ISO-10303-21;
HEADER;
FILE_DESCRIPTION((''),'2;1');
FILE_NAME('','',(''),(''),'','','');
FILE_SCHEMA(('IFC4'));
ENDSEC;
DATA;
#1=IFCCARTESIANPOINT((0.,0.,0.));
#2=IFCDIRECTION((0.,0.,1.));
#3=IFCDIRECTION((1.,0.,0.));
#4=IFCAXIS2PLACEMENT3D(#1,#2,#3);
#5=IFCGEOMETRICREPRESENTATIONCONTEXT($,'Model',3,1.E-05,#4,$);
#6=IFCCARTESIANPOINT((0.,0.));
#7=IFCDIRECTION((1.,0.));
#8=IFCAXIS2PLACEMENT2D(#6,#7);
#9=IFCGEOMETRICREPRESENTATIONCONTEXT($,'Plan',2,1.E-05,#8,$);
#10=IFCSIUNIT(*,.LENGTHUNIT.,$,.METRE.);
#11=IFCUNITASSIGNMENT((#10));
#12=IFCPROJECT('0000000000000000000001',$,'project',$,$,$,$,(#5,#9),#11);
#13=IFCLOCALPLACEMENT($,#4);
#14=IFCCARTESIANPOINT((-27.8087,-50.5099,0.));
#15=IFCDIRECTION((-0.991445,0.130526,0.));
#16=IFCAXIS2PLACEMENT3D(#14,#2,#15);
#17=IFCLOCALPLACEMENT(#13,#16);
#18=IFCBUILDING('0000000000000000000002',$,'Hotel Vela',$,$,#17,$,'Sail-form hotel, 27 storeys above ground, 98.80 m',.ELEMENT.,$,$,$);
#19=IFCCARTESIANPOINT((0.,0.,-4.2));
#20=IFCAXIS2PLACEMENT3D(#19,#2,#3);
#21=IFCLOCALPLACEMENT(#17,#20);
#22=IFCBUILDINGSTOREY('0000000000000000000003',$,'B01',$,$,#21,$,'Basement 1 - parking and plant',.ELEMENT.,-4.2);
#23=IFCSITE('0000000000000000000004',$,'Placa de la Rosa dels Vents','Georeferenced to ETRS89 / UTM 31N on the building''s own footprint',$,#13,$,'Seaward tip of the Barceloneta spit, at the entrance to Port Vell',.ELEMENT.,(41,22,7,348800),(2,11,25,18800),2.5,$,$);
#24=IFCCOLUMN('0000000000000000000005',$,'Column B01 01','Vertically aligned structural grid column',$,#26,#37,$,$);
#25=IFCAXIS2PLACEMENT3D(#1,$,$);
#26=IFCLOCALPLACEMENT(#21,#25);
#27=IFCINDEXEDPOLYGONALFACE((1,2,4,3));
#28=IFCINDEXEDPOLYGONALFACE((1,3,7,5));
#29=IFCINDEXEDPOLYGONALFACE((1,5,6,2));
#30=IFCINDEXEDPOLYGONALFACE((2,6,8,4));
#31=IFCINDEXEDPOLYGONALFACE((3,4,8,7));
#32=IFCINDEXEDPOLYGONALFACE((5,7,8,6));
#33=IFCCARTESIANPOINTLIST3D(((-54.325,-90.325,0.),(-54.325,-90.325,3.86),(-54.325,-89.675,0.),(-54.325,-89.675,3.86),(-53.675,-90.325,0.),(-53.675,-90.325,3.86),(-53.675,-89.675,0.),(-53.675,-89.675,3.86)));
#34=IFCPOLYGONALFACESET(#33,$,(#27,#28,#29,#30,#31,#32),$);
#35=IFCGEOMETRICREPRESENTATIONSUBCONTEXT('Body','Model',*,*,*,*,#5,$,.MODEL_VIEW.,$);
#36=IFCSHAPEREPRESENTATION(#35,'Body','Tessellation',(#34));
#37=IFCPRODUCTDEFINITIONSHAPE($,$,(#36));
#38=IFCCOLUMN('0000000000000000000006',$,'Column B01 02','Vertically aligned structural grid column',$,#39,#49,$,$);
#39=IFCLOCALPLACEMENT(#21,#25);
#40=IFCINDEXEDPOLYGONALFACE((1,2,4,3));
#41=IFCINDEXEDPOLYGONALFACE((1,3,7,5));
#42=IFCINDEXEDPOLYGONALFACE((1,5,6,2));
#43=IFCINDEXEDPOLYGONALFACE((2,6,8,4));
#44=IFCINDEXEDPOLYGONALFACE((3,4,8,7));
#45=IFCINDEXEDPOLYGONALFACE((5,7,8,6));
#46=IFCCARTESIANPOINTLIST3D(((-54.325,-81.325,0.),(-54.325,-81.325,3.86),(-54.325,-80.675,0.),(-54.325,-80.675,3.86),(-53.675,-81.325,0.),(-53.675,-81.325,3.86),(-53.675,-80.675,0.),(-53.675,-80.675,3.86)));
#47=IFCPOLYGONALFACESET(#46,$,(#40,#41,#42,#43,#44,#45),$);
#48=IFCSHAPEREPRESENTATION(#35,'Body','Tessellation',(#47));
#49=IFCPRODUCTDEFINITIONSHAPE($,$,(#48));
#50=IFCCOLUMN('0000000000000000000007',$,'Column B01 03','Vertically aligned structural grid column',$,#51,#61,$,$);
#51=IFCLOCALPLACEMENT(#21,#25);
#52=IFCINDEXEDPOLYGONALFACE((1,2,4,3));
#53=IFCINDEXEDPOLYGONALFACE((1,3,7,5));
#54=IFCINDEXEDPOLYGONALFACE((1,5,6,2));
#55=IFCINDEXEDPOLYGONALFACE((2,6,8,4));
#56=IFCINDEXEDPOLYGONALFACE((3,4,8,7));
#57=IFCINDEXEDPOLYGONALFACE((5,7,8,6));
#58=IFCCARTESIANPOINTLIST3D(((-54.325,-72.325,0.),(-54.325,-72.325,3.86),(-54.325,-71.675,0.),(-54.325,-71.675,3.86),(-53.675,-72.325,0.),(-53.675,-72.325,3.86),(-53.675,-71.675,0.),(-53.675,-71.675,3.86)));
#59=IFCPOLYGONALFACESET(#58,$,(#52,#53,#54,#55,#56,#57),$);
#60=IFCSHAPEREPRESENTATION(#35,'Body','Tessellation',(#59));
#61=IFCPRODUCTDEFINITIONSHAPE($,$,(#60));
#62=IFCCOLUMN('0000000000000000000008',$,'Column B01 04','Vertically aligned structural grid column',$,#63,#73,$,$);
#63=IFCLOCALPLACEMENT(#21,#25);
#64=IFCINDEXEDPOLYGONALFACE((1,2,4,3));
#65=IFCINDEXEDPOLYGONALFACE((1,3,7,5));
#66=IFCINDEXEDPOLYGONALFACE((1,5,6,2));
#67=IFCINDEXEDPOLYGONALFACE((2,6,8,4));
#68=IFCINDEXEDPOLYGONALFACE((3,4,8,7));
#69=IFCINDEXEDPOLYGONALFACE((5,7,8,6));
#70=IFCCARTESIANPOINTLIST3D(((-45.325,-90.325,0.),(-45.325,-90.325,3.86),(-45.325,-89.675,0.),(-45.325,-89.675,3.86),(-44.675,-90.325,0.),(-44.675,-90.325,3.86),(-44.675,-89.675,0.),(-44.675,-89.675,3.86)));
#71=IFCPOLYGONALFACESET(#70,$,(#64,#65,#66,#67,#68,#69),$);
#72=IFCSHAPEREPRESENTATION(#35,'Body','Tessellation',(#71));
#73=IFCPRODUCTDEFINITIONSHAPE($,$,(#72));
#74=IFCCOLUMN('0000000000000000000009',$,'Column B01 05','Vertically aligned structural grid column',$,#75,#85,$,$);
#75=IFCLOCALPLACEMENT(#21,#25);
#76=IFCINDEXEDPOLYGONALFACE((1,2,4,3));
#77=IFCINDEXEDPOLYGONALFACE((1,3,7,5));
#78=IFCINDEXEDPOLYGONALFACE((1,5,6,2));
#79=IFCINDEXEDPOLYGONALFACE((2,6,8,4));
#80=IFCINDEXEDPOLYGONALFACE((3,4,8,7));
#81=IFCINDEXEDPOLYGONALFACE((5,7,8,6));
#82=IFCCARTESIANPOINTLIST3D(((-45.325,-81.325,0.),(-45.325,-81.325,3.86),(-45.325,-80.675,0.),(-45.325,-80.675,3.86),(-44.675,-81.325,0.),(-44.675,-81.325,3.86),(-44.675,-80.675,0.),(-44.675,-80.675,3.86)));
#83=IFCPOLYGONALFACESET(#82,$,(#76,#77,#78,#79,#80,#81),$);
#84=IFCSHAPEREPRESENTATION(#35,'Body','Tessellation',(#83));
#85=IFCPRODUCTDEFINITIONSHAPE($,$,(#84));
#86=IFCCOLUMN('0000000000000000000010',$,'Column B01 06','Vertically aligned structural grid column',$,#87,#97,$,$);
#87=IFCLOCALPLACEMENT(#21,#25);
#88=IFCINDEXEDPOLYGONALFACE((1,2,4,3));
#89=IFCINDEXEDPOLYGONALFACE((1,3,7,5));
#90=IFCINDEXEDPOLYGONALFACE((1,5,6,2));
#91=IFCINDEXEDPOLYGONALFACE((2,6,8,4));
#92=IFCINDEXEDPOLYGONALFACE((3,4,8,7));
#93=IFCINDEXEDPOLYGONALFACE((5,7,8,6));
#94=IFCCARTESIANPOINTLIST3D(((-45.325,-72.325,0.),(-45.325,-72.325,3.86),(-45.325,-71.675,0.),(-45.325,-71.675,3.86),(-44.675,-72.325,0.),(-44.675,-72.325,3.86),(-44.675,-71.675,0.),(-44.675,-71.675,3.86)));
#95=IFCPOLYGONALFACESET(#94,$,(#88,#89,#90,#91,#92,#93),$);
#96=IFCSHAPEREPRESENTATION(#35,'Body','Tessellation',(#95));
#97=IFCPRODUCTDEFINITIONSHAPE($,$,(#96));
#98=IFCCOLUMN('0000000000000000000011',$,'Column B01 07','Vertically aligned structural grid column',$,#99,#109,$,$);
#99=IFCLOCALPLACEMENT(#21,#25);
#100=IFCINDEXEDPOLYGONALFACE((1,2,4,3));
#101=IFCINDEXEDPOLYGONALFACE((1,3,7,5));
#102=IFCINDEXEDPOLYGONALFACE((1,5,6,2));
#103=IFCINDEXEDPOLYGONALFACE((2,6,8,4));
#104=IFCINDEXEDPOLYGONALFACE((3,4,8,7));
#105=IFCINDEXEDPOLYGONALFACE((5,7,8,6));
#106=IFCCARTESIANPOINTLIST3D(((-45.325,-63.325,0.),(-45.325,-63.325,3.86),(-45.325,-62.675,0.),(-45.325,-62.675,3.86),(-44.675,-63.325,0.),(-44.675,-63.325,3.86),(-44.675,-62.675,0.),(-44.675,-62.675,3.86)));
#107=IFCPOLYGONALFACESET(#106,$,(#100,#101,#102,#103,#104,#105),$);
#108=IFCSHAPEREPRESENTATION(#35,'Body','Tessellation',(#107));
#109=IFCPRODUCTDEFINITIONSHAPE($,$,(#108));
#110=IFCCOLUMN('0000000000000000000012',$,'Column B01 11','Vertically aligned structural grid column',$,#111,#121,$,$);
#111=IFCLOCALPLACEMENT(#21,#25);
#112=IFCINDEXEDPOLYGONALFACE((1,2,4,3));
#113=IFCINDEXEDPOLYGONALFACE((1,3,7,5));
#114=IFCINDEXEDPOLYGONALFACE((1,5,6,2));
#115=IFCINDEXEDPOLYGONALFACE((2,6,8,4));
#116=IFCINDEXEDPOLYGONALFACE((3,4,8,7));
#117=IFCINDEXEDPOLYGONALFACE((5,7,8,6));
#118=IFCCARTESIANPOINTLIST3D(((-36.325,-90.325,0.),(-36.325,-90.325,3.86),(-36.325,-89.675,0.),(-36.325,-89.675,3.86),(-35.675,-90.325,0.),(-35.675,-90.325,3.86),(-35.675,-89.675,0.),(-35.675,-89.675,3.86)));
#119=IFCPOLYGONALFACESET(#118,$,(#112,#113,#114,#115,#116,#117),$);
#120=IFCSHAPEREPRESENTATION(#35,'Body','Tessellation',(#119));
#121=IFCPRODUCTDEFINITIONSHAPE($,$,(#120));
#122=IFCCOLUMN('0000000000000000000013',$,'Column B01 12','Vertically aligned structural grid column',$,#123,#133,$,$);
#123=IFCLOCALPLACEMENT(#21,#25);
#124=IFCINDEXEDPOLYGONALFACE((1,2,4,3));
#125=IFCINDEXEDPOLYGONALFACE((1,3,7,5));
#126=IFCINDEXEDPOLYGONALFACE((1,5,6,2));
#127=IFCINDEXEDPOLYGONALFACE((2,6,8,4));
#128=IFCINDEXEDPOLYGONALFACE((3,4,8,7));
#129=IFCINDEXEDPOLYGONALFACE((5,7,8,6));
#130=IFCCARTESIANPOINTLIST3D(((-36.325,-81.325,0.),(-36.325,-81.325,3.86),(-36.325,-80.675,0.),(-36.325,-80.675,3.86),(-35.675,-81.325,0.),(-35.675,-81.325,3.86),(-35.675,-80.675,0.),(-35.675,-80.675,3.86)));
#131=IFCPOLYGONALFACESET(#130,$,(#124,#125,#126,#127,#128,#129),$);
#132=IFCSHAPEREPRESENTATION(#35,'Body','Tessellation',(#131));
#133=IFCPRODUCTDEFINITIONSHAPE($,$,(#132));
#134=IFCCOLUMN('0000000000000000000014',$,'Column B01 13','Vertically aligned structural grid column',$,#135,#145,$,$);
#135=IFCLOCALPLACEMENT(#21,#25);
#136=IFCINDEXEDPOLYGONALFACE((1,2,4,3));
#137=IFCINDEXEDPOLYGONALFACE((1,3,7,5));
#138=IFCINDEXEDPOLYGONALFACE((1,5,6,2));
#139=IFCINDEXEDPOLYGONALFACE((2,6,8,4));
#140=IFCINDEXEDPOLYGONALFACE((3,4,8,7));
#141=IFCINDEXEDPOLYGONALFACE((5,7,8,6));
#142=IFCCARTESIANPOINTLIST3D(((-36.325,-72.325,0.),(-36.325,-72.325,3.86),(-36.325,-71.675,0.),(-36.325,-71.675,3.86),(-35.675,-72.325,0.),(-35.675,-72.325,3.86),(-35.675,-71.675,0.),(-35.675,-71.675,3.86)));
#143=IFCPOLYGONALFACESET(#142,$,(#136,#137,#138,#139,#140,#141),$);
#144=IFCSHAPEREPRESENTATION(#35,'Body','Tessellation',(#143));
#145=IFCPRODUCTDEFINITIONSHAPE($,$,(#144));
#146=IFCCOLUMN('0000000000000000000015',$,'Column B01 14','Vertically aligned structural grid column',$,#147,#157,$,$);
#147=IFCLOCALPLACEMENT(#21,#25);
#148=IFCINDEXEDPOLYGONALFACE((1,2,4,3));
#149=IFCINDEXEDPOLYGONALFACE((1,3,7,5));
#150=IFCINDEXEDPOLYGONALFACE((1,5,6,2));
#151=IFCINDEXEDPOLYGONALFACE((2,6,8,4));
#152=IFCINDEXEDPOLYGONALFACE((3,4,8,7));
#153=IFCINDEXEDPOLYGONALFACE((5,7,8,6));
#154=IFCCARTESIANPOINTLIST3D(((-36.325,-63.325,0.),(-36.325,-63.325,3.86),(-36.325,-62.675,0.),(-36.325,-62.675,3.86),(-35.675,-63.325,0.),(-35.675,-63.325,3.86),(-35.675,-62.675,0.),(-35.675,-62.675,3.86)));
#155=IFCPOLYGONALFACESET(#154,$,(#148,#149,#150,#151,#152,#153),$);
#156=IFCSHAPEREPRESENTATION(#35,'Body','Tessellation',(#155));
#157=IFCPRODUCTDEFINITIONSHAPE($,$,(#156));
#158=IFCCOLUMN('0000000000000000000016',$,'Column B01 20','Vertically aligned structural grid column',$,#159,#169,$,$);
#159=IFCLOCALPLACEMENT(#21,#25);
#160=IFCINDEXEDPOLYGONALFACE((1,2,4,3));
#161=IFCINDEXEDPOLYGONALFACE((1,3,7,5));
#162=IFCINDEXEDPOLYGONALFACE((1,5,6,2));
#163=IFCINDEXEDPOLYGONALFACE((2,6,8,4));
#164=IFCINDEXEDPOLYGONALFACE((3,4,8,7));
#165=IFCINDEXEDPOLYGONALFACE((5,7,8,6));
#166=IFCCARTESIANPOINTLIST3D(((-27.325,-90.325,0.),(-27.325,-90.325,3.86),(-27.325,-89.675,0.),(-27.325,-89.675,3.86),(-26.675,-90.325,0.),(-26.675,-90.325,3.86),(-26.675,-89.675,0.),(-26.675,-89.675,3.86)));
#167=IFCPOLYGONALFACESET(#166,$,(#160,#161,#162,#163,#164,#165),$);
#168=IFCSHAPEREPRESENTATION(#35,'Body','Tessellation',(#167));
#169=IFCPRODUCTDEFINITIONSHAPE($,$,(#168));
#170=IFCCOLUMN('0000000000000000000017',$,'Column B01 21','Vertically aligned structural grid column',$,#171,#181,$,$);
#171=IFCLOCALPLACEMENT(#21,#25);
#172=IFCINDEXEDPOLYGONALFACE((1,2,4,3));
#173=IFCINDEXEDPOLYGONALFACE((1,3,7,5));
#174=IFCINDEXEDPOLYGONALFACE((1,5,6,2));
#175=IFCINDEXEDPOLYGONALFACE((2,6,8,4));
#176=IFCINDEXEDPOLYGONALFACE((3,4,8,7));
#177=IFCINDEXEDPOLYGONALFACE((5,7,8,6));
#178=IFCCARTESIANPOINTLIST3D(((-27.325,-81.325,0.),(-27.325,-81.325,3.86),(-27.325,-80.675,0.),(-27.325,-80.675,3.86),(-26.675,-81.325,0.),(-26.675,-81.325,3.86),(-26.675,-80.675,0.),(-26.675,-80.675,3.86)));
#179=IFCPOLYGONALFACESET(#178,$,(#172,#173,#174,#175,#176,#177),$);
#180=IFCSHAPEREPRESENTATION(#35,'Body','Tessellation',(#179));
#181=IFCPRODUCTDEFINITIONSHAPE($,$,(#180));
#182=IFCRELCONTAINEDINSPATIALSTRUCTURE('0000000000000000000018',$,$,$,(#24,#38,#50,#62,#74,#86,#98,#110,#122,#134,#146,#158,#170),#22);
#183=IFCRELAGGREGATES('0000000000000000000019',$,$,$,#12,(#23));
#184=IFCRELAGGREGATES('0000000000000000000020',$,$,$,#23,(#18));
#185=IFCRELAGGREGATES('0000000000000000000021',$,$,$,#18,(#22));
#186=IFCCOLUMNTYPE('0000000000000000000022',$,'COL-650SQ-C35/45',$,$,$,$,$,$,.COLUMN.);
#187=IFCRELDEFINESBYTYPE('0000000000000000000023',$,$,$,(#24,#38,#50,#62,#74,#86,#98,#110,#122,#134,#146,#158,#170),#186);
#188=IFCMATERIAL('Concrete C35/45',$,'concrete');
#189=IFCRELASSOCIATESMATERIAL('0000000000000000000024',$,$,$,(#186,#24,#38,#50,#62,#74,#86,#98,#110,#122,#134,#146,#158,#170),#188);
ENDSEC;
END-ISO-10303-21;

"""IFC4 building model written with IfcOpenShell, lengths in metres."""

from ifc_helpers import new_model, si_unit, frame, origin_with_axes, origin_2d_with_axis, place, context, subcontext, project, spatial, line, indexed_curve, rectangle, outline, extrude, material, material_profile, profile_set, profile_usage, type_object, element, save


model = new_model("IFC4")

# Units and contexts
model_context = context("Model", 3, precision=1e-05, world=origin_with_axes())
plan_context = context("Plan", 2, precision=1e-05, world=origin_2d_with_axis())
body_context = subcontext(model_context, "Body", "Model", "MODEL_VIEW")
ifc_project = project(units=[si_unit("LENGTHUNIT", "METRE")], contexts=[model_context, plan_context])

# Site, building, storey
site_placement = place(None, origin_with_axes())
site = spatial("IfcSite", under=ifc_project, at=site_placement, Name="Placa de la Rosa dels Vents", Description="Georeferenced to ETRS89 / UTM 31N on the building's own footprint", LongName="Seaward tip of the Barceloneta spit, at the entrance to Port Vell", CompositionType="ELEMENT", RefLatitude=(41, 22, 7, 348800), RefLongitude=(2, 11, 25, 18800), RefElevation=2.5)
building_placement = place(site_placement, frame((-27.8087, -50.5099, 0.0), z_axis=(0.0, 0.0, 1.0), x_axis=(-0.991445, 0.130526, 0.0)))
building = spatial("IfcBuilding", under=site, at=building_placement, Name="Hotel Vela", LongName="Sail-form hotel, 27 storeys above ground, 98.80 m", CompositionType="ELEMENT")
storey_placement = place(building_placement, frame((0.0, 0.0, -4.2), z_axis=(0.0, 0.0, 1.0), x_axis=(1.0, 0.0, 0.0)))
storey = spatial("IfcBuildingStorey", under=building, at=storey_placement, Name="B01", LongName="Basement 1 - parking and plant", CompositionType="ELEMENT", Elevation=-4.2)

# Columns
ifc_material = material(Name="Concrete C35/45", Category="concrete")
ifc_material_profile = material_profile(ifc_material, rectangle(XDim=0.65, YDim=0.65))
ifc_profile_set = profile_set([ifc_material_profile], Name="COL-650SQ-C35/45")
ifc_profile_usage_1 = profile_usage(ifc_profile_set)
column_type = type_object("IfcColumnType", Name="COL-650SQ-C35/45", PredefinedType="COLUMN", material=ifc_profile_set)
column_1_placement = place(storey_placement, frame((-54.325, -90.325, 0.0), z_axis=(0.0, 0.0, 1.0), x_axis=(1.0, 0.0, 0.0)))
element("IfcColumn", 1, at=column_1_placement, inside=storey, type_object=column_type, material=ifc_profile_usage_1, Name="Column B01 01", Description="Vertically aligned structural grid column", context=body_context, shape_type="SweptSolid", body=[
    extrude(outline(indexed_curve([(0.0, 0.0), (0.65, 0.0), (0.65, 0.65), (0.0, 0.65)], segments=[line(1, 2, 3, 4, 1)])), origin_with_axes(), (0.0, 0.0, 1.0), 3.86),
])
ifc_profile_usage_2 = profile_usage(ifc_profile_set)
column_2_placement = place(storey_placement, frame((-54.325, -81.325, 0.0), z_axis=(0.0, 0.0, 1.0), x_axis=(1.0, 0.0, 0.0)))
element("IfcColumn", 2, at=column_2_placement, inside=storey, type_object=column_type, material=ifc_profile_usage_2, Name="Column B01 02", Description="Vertically aligned structural grid column", context=body_context, shape_type="SweptSolid", body=[
    extrude(outline(indexed_curve([(0.0, 0.0), (0.65, 0.0), (0.65, 0.65), (0.0, 0.65)], segments=[line(1, 2, 3, 4, 1)])), origin_with_axes(), (0.0, 0.0, 1.0), 3.86),
])
ifc_profile_usage_3 = profile_usage(ifc_profile_set)
column_3_placement = place(storey_placement, frame((-54.325, -72.325, 0.0), z_axis=(0.0, 0.0, 1.0), x_axis=(1.0, 0.0, 0.0)))
element("IfcColumn", 3, at=column_3_placement, inside=storey, type_object=column_type, material=ifc_profile_usage_3, Name="Column B01 03", Description="Vertically aligned structural grid column", context=body_context, shape_type="SweptSolid", body=[
    extrude(outline(indexed_curve([(0.0, 0.0), (0.65, 0.0), (0.65, 0.65), (0.0, 0.65)], segments=[line(1, 2, 3, 4, 1)])), origin_with_axes(), (0.0, 0.0, 1.0), 3.86),
])
ifc_profile_usage_4 = profile_usage(ifc_profile_set)
column_4_placement = place(storey_placement, frame((-45.325, -90.325, 0.0), z_axis=(0.0, 0.0, 1.0), x_axis=(1.0, 0.0, 0.0)))
element("IfcColumn", 4, at=column_4_placement, inside=storey, type_object=column_type, material=ifc_profile_usage_4, Name="Column B01 04", Description="Vertically aligned structural grid column", context=body_context, shape_type="SweptSolid", body=[
    extrude(outline(indexed_curve([(0.0, 0.0), (0.65, 0.0), (0.65, 0.65), (0.0, 0.65)], segments=[line(1, 2, 3, 4, 1)])), origin_with_axes(), (0.0, 0.0, 1.0), 3.86),
])
ifc_profile_usage_5 = profile_usage(ifc_profile_set)
column_5_placement = place(storey_placement, frame((-45.325, -81.325, 0.0), z_axis=(0.0, 0.0, 1.0), x_axis=(1.0, 0.0, 0.0)))
element("IfcColumn", 5, at=column_5_placement, inside=storey, type_object=column_type, material=ifc_profile_usage_5, Name="Column B01 05", Description="Vertically aligned structural grid column", context=body_context, shape_type="SweptSolid", body=[
    extrude(outline(indexed_curve([(0.0, 0.0), (0.65, 0.0), (0.65, 0.65), (0.0, 0.65)], segments=[line(1, 2, 3, 4, 1)])), origin_with_axes(), (0.0, 0.0, 1.0), 3.86),
])
ifc_profile_usage_6 = profile_usage(ifc_profile_set)
column_6_placement = place(storey_placement, frame((-45.325, -72.325, 0.0), z_axis=(0.0, 0.0, 1.0), x_axis=(1.0, 0.0, 0.0)))
element("IfcColumn", 6, at=column_6_placement, inside=storey, type_object=column_type, material=ifc_profile_usage_6, Name="Column B01 06", Description="Vertically aligned structural grid column", context=body_context, shape_type="SweptSolid", body=[
    extrude(outline(indexed_curve([(0.0, 0.0), (0.65, 0.0), (0.65, 0.65), (0.0, 0.65)], segments=[line(1, 2, 3, 4, 1)])), origin_with_axes(), (0.0, 0.0, 1.0), 3.86),
])
ifc_profile_usage_7 = profile_usage(ifc_profile_set)
column_7_placement = place(storey_placement, frame((-45.325, -63.325, 0.0), z_axis=(0.0, 0.0, 1.0), x_axis=(1.0, 0.0, 0.0)))
element("IfcColumn", 7, at=column_7_placement, inside=storey, type_object=column_type, material=ifc_profile_usage_7, Name="Column B01 07", Description="Vertically aligned structural grid column", context=body_context, shape_type="SweptSolid", body=[
    extrude(outline(indexed_curve([(0.0, 0.0), (0.65, 0.0), (0.65, 0.65), (0.0, 0.65)], segments=[line(1, 2, 3, 4, 1)])), origin_with_axes(), (0.0, 0.0, 1.0), 3.86),
])
ifc_profile_usage_8 = profile_usage(ifc_profile_set)
column_8_placement = place(storey_placement, frame((-36.325, -90.325, 0.0), z_axis=(0.0, 0.0, 1.0), x_axis=(1.0, 0.0, 0.0)))
element("IfcColumn", 8, at=column_8_placement, inside=storey, type_object=column_type, material=ifc_profile_usage_8, Name="Column B01 11", Description="Vertically aligned structural grid column", context=body_context, shape_type="SweptSolid", body=[
    extrude(outline(indexed_curve([(0.0, 0.0), (0.65, 0.0), (0.65, 0.65), (0.0, 0.65)], segments=[line(1, 2, 3, 4, 1)])), origin_with_axes(), (0.0, 0.0, 1.0), 3.86),
])
ifc_profile_usage_9 = profile_usage(ifc_profile_set)
column_9_placement = place(storey_placement, frame((-36.325, -81.325, 0.0), z_axis=(0.0, 0.0, 1.0), x_axis=(1.0, 0.0, 0.0)))
element("IfcColumn", 9, at=column_9_placement, inside=storey, type_object=column_type, material=ifc_profile_usage_9, Name="Column B01 12", Description="Vertically aligned structural grid column", context=body_context, shape_type="SweptSolid", body=[
    extrude(outline(indexed_curve([(0.0, 0.0), (0.65, 0.0), (0.65, 0.65), (0.0, 0.65)], segments=[line(1, 2, 3, 4, 1)])), origin_with_axes(), (0.0, 0.0, 1.0), 3.86),
])
ifc_profile_usage_10 = profile_usage(ifc_profile_set)
column_10_placement = place(storey_placement, frame((-36.325, -72.325, 0.0), z_axis=(0.0, 0.0, 1.0), x_axis=(1.0, 0.0, 0.0)))
element("IfcColumn", 10, at=column_10_placement, inside=storey, type_object=column_type, material=ifc_profile_usage_10, Name="Column B01 13", Description="Vertically aligned structural grid column", context=body_context, shape_type="SweptSolid", body=[
    extrude(outline(indexed_curve([(0.0, 0.0), (0.65, 0.0), (0.65, 0.65), (0.0, 0.65)], segments=[line(1, 2, 3, 4, 1)])), origin_with_axes(), (0.0, 0.0, 1.0), 3.86),
])
ifc_profile_usage_11 = profile_usage(ifc_profile_set)
column_11_placement = place(storey_placement, frame((-36.325, -63.325, 0.0), z_axis=(0.0, 0.0, 1.0), x_axis=(1.0, 0.0, 0.0)))
element("IfcColumn", 11, at=column_11_placement, inside=storey, type_object=column_type, material=ifc_profile_usage_11, Name="Column B01 14", Description="Vertically aligned structural grid column", context=body_context, shape_type="SweptSolid", body=[
    extrude(outline(indexed_curve([(0.0, 0.0), (0.65, 0.0), (0.65, 0.65), (0.0, 0.65)], segments=[line(1, 2, 3, 4, 1)])), origin_with_axes(), (0.0, 0.0, 1.0), 3.86),
])
ifc_profile_usage_12 = profile_usage(ifc_profile_set)
column_12_placement = place(storey_placement, frame((-27.325, -90.325, 0.0), z_axis=(0.0, 0.0, 1.0), x_axis=(1.0, 0.0, 0.0)))
element("IfcColumn", 12, at=column_12_placement, inside=storey, type_object=column_type, material=ifc_profile_usage_12, Name="Column B01 20", Description="Vertically aligned structural grid column", context=body_context, shape_type="SweptSolid", body=[
    extrude(outline(indexed_curve([(0.0, 0.0), (0.65, 0.0), (0.65, 0.65), (0.0, 0.65)], segments=[line(1, 2, 3, 4, 1)])), origin_with_axes(), (0.0, 0.0, 1.0), 3.86),
])
ifc_profile_usage_13 = profile_usage(ifc_profile_set)
column_13_placement = place(storey_placement, frame((-27.325, -81.325, 0.0), z_axis=(0.0, 0.0, 1.0), x_axis=(1.0, 0.0, 0.0)))
element("IfcColumn", 13, at=column_13_placement, inside=storey, type_object=column_type, material=ifc_profile_usage_13, Name="Column B01 21", Description="Vertically aligned structural grid column", context=body_context, shape_type="SweptSolid", body=[
    extrude(outline(indexed_curve([(0.0, 0.0), (0.65, 0.0), (0.65, 0.65), (0.0, 0.65)], segments=[line(1, 2, 3, 4, 1)])), origin_with_axes(), (0.0, 0.0, 1.0), 3.86),
])

save(model, "model.ifc")
